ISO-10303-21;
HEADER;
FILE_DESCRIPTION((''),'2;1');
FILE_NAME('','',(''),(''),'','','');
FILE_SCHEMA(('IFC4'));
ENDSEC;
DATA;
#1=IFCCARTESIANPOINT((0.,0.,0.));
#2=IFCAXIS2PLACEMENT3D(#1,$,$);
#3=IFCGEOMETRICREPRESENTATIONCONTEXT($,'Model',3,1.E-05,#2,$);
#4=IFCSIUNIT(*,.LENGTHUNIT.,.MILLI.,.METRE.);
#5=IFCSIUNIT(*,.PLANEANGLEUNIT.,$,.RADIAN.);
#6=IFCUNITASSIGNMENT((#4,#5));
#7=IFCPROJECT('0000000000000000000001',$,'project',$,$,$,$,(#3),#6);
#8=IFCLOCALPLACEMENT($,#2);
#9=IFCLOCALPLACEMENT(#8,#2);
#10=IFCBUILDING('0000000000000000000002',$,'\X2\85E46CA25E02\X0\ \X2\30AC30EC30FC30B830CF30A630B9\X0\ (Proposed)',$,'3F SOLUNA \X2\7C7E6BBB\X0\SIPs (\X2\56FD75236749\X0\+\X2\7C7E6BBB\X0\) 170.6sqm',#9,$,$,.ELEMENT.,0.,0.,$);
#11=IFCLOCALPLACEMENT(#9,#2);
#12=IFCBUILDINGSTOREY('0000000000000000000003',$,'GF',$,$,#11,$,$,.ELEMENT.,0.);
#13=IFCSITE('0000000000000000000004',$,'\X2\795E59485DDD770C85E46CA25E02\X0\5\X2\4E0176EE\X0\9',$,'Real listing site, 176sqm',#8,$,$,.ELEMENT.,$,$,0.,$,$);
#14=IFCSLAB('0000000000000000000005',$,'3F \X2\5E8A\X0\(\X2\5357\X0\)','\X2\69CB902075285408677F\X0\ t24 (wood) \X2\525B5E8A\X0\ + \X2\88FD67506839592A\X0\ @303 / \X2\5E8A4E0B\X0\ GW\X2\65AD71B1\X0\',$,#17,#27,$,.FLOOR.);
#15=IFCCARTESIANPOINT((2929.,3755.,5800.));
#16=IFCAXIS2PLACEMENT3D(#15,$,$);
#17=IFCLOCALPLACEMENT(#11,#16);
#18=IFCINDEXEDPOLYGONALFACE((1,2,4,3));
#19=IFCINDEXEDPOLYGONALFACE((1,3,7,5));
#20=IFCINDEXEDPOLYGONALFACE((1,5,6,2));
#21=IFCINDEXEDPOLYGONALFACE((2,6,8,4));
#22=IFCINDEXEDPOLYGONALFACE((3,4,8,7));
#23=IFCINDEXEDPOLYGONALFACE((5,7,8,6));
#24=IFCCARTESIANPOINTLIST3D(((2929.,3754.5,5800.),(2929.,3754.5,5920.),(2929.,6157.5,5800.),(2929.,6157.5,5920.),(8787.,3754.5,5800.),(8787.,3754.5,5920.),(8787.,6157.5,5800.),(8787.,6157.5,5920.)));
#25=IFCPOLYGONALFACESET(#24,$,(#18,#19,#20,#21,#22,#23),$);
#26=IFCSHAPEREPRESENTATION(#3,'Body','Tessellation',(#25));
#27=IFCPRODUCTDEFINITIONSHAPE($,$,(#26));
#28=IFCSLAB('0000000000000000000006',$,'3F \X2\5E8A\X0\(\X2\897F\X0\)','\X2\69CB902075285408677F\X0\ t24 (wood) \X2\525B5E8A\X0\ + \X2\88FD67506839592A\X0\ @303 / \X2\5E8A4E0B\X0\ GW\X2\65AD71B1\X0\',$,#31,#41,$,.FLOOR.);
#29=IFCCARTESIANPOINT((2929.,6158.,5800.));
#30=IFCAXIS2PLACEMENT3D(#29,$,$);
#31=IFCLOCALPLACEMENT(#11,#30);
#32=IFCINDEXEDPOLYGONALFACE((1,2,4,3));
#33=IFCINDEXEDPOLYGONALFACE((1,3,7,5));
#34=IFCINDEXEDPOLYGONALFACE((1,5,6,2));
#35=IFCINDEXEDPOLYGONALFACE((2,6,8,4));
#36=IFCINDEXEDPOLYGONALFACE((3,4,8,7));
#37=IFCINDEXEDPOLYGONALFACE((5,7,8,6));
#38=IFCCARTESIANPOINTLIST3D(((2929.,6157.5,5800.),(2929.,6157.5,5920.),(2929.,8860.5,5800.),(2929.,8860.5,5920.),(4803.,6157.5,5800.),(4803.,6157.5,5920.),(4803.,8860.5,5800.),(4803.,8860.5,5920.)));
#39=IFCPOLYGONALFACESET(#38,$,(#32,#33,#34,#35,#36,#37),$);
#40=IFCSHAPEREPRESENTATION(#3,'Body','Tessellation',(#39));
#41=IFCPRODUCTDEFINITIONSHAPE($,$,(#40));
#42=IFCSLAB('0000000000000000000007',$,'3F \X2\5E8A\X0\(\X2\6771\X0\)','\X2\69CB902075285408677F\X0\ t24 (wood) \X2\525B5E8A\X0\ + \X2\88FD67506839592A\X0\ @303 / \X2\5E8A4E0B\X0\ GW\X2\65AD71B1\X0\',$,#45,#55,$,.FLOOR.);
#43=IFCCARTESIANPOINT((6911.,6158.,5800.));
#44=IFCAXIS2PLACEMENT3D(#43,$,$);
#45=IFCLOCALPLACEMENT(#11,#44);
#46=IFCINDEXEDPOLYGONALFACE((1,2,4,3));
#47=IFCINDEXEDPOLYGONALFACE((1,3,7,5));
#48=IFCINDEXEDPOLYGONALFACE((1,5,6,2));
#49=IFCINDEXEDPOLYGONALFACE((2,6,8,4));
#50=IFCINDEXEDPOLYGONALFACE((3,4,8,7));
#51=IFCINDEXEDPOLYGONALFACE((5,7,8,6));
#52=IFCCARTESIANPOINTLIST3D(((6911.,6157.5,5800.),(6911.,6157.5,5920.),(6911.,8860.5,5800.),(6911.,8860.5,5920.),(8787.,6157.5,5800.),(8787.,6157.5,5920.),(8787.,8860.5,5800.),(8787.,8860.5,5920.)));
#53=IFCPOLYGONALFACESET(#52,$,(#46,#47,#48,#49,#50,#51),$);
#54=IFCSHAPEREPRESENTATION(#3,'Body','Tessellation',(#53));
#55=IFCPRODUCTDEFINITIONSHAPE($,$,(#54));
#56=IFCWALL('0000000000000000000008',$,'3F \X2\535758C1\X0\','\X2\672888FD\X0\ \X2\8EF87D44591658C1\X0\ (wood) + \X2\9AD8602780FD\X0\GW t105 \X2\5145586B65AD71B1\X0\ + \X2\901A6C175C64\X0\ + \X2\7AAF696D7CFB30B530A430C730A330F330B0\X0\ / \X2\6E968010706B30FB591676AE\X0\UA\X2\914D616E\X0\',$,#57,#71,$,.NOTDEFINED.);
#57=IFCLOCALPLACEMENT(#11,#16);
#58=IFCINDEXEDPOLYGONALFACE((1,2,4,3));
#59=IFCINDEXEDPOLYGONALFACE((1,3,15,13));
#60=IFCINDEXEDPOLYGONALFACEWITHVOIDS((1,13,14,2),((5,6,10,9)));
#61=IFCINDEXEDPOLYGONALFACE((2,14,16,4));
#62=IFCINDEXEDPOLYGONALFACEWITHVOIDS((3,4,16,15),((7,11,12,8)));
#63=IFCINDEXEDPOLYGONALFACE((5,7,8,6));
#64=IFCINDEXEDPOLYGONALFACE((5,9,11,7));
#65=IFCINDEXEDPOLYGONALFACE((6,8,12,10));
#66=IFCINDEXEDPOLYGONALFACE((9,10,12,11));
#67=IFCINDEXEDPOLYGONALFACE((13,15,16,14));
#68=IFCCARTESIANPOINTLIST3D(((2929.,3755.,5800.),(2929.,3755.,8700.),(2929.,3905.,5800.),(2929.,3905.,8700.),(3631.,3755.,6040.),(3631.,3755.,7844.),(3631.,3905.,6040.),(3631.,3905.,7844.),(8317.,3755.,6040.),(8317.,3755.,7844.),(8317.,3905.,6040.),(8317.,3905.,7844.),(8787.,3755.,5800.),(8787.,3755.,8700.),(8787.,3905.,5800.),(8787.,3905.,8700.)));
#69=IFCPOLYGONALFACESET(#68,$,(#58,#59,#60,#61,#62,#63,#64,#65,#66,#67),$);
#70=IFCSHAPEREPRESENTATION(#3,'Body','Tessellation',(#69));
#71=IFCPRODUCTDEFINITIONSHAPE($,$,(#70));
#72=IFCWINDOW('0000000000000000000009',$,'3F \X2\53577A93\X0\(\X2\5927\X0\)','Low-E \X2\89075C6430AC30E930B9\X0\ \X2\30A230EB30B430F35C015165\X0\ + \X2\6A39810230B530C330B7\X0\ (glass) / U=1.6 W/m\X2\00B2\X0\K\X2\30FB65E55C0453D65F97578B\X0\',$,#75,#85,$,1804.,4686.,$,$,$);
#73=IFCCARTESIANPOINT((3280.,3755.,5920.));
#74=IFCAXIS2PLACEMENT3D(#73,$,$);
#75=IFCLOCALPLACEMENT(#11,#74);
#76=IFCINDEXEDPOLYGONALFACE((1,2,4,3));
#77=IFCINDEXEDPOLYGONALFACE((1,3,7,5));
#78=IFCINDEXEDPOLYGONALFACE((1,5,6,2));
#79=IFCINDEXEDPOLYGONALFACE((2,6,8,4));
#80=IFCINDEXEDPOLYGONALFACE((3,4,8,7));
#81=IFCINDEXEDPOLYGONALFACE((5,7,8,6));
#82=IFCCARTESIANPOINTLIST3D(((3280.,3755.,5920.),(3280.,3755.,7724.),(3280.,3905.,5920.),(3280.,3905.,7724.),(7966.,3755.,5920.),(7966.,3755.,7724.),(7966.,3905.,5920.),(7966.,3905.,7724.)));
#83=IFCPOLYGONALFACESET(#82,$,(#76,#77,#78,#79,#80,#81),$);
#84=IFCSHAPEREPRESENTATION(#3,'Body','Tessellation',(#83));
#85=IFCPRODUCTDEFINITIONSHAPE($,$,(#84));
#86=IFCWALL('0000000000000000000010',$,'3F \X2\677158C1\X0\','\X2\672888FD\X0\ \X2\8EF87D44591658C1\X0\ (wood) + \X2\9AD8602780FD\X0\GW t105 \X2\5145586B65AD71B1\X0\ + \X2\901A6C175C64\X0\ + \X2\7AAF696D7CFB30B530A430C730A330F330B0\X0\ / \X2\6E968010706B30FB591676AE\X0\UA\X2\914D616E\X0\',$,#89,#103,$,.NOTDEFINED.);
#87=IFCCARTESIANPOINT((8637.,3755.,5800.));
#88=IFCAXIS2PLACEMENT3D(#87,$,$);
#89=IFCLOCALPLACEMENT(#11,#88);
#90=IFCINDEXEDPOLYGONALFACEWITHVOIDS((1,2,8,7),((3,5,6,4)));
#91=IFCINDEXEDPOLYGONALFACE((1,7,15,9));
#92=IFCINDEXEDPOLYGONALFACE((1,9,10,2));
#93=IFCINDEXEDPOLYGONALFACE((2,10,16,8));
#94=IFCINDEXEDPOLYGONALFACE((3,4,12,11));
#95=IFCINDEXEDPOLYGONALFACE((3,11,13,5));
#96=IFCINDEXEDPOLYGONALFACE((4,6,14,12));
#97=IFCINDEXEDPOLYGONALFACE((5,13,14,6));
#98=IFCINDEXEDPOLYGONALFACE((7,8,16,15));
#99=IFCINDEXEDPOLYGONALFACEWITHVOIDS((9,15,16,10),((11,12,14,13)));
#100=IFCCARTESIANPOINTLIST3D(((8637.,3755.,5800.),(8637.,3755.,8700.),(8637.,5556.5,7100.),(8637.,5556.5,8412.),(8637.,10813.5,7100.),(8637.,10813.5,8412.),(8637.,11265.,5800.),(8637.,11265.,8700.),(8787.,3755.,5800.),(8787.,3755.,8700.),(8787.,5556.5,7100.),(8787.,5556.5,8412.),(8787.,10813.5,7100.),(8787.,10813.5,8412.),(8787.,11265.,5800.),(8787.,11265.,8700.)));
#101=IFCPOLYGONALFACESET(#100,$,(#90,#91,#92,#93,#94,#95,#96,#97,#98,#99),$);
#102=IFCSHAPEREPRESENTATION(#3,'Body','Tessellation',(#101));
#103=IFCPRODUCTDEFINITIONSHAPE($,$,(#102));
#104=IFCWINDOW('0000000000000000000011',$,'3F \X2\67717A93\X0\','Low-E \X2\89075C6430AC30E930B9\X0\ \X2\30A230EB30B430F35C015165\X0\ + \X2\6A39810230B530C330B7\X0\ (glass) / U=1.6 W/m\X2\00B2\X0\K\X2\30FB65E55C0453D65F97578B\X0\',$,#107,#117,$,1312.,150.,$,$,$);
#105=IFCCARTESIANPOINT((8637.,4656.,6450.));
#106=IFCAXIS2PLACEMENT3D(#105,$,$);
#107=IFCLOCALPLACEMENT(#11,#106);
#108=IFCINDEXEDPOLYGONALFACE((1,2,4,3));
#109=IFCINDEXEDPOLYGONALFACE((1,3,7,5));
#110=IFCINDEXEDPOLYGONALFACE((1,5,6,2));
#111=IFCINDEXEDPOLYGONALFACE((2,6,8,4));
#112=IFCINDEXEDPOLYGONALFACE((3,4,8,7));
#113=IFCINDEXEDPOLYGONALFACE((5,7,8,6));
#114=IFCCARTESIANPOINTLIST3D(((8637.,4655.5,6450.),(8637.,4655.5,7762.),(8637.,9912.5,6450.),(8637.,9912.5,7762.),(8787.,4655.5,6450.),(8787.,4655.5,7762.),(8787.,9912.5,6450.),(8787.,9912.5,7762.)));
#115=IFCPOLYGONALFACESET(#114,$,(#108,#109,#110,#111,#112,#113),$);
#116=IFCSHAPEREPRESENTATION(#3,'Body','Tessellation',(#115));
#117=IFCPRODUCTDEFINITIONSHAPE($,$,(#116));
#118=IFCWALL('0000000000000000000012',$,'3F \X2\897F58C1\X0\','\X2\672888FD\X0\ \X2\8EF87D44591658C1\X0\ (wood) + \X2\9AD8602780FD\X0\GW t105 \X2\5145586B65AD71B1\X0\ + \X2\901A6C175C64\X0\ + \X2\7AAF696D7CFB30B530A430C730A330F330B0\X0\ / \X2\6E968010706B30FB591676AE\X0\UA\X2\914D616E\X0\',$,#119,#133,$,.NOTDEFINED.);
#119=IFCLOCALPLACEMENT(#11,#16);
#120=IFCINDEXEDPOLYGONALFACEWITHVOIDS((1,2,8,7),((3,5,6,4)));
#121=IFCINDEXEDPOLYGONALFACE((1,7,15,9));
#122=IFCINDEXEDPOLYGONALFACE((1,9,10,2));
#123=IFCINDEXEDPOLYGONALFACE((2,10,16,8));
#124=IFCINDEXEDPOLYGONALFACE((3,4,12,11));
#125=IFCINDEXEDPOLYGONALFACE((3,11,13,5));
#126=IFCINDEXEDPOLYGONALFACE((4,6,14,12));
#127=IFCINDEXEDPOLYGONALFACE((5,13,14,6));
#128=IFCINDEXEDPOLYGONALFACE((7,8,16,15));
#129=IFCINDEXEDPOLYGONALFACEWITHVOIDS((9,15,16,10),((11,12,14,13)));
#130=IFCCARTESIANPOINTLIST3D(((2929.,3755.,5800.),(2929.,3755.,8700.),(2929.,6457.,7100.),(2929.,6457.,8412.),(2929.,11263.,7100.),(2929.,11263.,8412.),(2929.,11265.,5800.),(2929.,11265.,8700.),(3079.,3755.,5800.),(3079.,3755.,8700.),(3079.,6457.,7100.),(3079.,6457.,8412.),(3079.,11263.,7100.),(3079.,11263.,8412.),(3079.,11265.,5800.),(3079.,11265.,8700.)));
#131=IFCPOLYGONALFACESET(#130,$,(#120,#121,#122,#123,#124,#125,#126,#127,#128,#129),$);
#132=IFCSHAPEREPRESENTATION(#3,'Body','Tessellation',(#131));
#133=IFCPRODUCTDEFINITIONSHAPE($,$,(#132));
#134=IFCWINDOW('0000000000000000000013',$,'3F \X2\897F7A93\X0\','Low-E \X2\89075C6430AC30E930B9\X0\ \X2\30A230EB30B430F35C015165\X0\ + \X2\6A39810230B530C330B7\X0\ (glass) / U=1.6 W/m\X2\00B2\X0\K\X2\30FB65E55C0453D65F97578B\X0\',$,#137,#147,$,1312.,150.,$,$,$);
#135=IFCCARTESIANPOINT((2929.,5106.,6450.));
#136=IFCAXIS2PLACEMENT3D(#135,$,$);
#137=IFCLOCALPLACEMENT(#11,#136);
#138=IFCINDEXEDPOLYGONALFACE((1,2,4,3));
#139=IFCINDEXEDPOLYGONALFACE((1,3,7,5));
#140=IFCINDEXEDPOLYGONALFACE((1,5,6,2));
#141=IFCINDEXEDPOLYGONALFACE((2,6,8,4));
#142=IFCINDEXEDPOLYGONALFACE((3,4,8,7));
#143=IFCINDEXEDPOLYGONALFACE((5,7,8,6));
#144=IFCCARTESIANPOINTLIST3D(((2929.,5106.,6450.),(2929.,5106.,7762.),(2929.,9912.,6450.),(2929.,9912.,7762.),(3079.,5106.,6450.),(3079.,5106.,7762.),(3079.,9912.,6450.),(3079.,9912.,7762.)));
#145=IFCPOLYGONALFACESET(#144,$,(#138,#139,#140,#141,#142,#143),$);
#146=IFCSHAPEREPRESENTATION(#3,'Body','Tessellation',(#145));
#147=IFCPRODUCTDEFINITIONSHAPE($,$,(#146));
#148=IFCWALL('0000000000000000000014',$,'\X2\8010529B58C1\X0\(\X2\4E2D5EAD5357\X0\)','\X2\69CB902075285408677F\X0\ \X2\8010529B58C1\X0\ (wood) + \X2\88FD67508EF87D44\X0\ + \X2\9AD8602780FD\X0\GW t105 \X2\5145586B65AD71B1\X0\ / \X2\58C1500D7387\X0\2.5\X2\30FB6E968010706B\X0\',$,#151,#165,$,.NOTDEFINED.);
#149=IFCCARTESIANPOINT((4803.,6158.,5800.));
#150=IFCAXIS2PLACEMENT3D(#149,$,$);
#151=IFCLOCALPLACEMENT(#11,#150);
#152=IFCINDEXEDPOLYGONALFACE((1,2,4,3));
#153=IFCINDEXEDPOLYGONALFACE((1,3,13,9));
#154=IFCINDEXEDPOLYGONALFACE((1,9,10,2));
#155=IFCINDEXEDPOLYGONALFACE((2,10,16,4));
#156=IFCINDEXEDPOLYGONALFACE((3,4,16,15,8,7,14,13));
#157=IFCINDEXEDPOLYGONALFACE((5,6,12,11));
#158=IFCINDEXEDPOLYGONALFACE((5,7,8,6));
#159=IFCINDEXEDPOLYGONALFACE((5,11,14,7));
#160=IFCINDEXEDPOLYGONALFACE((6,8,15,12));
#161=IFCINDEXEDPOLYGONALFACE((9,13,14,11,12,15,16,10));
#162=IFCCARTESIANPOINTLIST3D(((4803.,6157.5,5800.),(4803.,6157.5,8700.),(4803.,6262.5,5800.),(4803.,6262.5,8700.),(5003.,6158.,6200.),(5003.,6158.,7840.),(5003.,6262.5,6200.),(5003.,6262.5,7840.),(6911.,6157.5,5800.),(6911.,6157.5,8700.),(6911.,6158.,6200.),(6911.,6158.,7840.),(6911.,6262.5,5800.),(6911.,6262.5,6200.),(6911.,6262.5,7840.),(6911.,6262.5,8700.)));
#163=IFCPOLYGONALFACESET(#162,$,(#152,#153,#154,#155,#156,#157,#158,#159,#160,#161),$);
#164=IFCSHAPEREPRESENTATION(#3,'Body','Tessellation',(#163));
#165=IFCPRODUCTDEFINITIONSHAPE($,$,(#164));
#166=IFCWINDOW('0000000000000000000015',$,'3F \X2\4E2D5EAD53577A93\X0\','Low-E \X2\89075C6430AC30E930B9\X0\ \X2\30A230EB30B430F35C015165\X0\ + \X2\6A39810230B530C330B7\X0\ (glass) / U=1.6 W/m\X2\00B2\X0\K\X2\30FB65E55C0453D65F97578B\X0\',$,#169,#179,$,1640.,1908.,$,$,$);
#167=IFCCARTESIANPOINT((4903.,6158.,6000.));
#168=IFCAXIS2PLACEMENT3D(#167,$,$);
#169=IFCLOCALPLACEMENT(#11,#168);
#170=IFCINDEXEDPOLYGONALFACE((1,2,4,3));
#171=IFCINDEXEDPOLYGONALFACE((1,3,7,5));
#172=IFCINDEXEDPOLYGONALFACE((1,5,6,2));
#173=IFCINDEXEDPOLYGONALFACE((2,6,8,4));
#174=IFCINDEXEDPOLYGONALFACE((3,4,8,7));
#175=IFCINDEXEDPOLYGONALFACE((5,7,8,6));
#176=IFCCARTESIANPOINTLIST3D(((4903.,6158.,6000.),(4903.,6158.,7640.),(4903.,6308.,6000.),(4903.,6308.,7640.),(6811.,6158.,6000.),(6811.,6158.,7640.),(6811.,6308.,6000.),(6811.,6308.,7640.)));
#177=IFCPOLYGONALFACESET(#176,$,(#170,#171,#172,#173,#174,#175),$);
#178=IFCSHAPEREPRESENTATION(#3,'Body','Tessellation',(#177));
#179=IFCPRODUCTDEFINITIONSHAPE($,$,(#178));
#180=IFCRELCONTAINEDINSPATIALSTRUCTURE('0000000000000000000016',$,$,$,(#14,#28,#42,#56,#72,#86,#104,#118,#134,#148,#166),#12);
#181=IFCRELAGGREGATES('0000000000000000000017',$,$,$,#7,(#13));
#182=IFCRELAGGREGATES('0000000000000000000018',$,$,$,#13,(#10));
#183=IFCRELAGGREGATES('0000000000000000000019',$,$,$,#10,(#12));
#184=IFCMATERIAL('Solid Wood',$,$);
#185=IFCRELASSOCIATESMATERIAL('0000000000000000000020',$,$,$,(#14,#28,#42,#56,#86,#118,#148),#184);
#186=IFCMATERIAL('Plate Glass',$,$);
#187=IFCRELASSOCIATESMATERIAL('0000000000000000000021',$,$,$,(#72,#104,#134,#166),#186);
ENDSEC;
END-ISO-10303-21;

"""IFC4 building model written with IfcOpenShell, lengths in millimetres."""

from ifc_helpers import new_model, si_unit, frame, frame_2d, origin, place, context, project, spatial, rectangle, extrude, material, element, fill, save


model = new_model("IFC4")

# Units and contexts
model_context = context("Model", 3, precision=1e-05, world=origin())
ifc_project = project(units=[si_unit("LENGTHUNIT", "METRE", prefix="MILLI"), si_unit("PLANEANGLEUNIT", "RADIAN")], contexts=[model_context])

# Site, building, storey
site_placement = place(None, origin())
site = spatial("IfcSite", under=ifc_project, at=site_placement, Name="神奈川県藤沢市5丁目9", ObjectType="Real listing site, 176sqm", CompositionType="ELEMENT", RefElevation=0.0)
building_placement = place(site_placement, origin())
building = spatial("IfcBuilding", under=site, at=building_placement, Name="藤沢市 ガレージハウス (Proposed)", ObjectType="3F SOLUNA 籾殻SIPs (国産杉+籾殻) 170.6sqm", CompositionType="ELEMENT", ElevationOfRefHeight=0.0, ElevationOfTerrain=0.0)
storey_placement = place(building_placement, origin())
storey = spatial("IfcBuildingStorey", under=building, at=storey_placement, Name="GF", CompositionType="ELEMENT", Elevation=0.0)

# Slabs
ifc_material_1 = material(Name="Solid Wood")
slab_1_placement = place(storey_placement, frame((2929.0, 3755.0, 5800.0)))
element("IfcSlab", 1, at=slab_1_placement, inside=storey, material=ifc_material_1, Name="3F 床(南)", Description="構造用合板 t24 (wood) 剛床 + 製材根太 @303 / 床下 GW断熱", PredefinedType="FLOOR", context=model_context, shape_type="SweptSolid", body=[
    extrude(rectangle(XDim=5858.0, YDim=2403.0, at=frame_2d((2929.0, 1201.0))), frame((2929.0, 3755.0, 5800.0)), (0.0, 0.0, 1.0), 120.0),
])
slab_2_placement = place(storey_placement, frame((2929.0, 6158.0, 5800.0)))
element("IfcSlab", 2, at=slab_2_placement, inside=storey, material=ifc_material_1, Name="3F 床(西)", Description="構造用合板 t24 (wood) 剛床 + 製材根太 @303 / 床下 GW断熱", PredefinedType="FLOOR", context=model_context, shape_type="SweptSolid", body=[
    extrude(rectangle(XDim=1874.0, YDim=2703.0, at=frame_2d((937.0, 1351.0))), frame((2929.0, 6158.0, 5800.0)), (0.0, 0.0, 1.0), 120.0),
])
slab_3_placement = place(storey_placement, frame((6911.0, 6158.0, 5800.0)))
element("IfcSlab", 3, at=slab_3_placement, inside=storey, material=ifc_material_1, Name="3F 床(東)", Description="構造用合板 t24 (wood) 剛床 + 製材根太 @303 / 床下 GW断熱", PredefinedType="FLOOR", context=model_context, shape_type="SweptSolid", body=[
    extrude(rectangle(XDim=1876.0, YDim=2703.0, at=frame_2d((938.0, 1351.0))), frame((6911.0, 6158.0, 5800.0)), (0.0, 0.0, 1.0), 120.0),
])

# Walls, openings, windows
wall_1_placement = place(storey_placement, frame((2929.0, 3755.0, 5800.0)))
wall_1 = element("IfcWall", 4, at=wall_1_placement, inside=storey, material=ifc_material_1, Name="3F 南壁", Description="木製 軸組外壁 (wood) + 高性能GW t105 充填断熱 + 通気層 + 窯業系サイディング / 準耐火・外皮UA配慮", PredefinedType="NOTDEFINED", context=model_context, shape_type="SweptSolid", body=[
    extrude(rectangle(XDim=5858.0, YDim=150.0, at=frame_2d((2929.0, 75.0))), frame((2929.0, 3755.0, 5800.0)), (0.0, 0.0, 1.0), 2900.0),
])
opening_1_placement = place(storey_placement, frame((3280.0, 3755.0, 5920.0)))
opening_1 = element("IfcOpeningElement", 5, at=opening_1_placement, cuts=wall_1, PredefinedType="NOTDEFINED", context=model_context, shape_type="SweptSolid", body=[
    extrude(rectangle(XDim=4686.0, YDim=150.0, at=frame_2d((2343.0, 75.0))), frame((3280.0, 3755.0, 5920.0)), (0.0, 0.0, 1.0), 1804.0),
])
ifc_material_2 = material(Name="Plate Glass")
window_1_placement = place(storey_placement, frame((3280.0, 3755.0, 5920.0)))
window_1 = element("IfcWindow", 6, at=window_1_placement, inside=storey, material=ifc_material_2, Name="3F 南窓(大)", Description="Low-E 複層ガラス アルゴン封入 + 樹脂サッシ (glass) / U=1.6 W/m²K・日射取得型", OverallHeight=1804.0, OverallWidth=4686.0, context=model_context, shape_type="SweptSolid", body=[
    extrude(rectangle(XDim=4686.0, YDim=150.0, at=frame_2d((2343.0, 75.0))), frame((3280.0, 3755.0, 5920.0)), (0.0, 0.0, 1.0), 1804.0),
])
fill(opening_1, window_1)
wall_2_placement = place(storey_placement, frame((8637.0, 3755.0, 5800.0)))
wall_2 = element("IfcWall", 7, at=wall_2_placement, inside=storey, material=ifc_material_1, Name="3F 東壁", Description="木製 軸組外壁 (wood) + 高性能GW t105 充填断熱 + 通気層 + 窯業系サイディング / 準耐火・外皮UA配慮", PredefinedType="NOTDEFINED", context=model_context, shape_type="SweptSolid", body=[
    extrude(rectangle(XDim=150.0, YDim=7510.0, at=frame_2d((75.0, 3755.0))), frame((8637.0, 3755.0, 5800.0)), (0.0, 0.0, 1.0), 2900.0),
])
opening_2_placement = place(storey_placement, frame((8637.0, 4656.0, 6450.0)))
opening_2 = element("IfcOpeningElement", 8, at=opening_2_placement, cuts=wall_2, PredefinedType="NOTDEFINED", context=model_context, shape_type="SweptSolid", body=[
    extrude(rectangle(XDim=150.0, YDim=5257.0, at=frame_2d((75.0, 2628.0))), frame((8637.0, 4656.0, 6450.0)), (0.0, 0.0, 1.0), 1312.0),
])
window_2_placement = place(storey_placement, frame((8637.0, 4656.0, 6450.0)))
window_2 = element("IfcWindow", 9, at=window_2_placement, inside=storey, material=ifc_material_2, Name="3F 東窓", Description="Low-E 複層ガラス アルゴン封入 + 樹脂サッシ (glass) / U=1.6 W/m²K・日射取得型", OverallHeight=1312.0, OverallWidth=150.0, context=model_context, shape_type="SweptSolid", body=[
    extrude(rectangle(XDim=150.0, YDim=5257.0, at=frame_2d((75.0, 2628.0))), frame((8637.0, 4656.0, 6450.0)), (0.0, 0.0, 1.0), 1312.0),
])
fill(opening_2, window_2)
wall_3_placement = place(storey_placement, frame((2929.0, 3755.0, 5800.0)))
wall_3 = element("IfcWall", 10, at=wall_3_placement, inside=storey, material=ifc_material_1, Name="3F 西壁", Description="木製 軸組外壁 (wood) + 高性能GW t105 充填断熱 + 通気層 + 窯業系サイディング / 準耐火・外皮UA配慮", PredefinedType="NOTDEFINED", context=model_context, shape_type="SweptSolid", body=[
    extrude(rectangle(XDim=150.0, YDim=7510.0, at=frame_2d((75.0, 3755.0))), frame((2929.0, 3755.0, 5800.0)), (0.0, 0.0, 1.0), 2900.0),
])
opening_3_placement = place(storey_placement, frame((2929.0, 5106.0, 6450.0)))
opening_3 = element("IfcOpeningElement", 11, at=opening_3_placement, cuts=wall_3, PredefinedType="NOTDEFINED", context=model_context, shape_type="SweptSolid", body=[
    extrude(rectangle(XDim=150.0, YDim=4806.0, at=frame_2d((75.0, 2403.0))), frame((2929.0, 5106.0, 6450.0)), (0.0, 0.0, 1.0), 1312.0),
])
window_3_placement = place(storey_placement, frame((2929.0, 5106.0, 6450.0)))
window_3 = element("IfcWindow", 12, at=window_3_placement, inside=storey, material=ifc_material_2, Name="3F 西窓", Description="Low-E 複層ガラス アルゴン封入 + 樹脂サッシ (glass) / U=1.6 W/m²K・日射取得型", OverallHeight=1312.0, OverallWidth=150.0, context=model_context, shape_type="SweptSolid", body=[
    extrude(rectangle(XDim=150.0, YDim=4806.0, at=frame_2d((75.0, 2403.0))), frame((2929.0, 5106.0, 6450.0)), (0.0, 0.0, 1.0), 1312.0),
])
fill(opening_3, window_3)
wall_4_placement = place(storey_placement, frame((4803.0, 6158.0, 5800.0)))
wall_4 = element("IfcWall", 13, at=wall_4_placement, inside=storey, material=ifc_material_1, Name="耐力壁(中庭南)", Description="構造用合板 耐力壁 (wood) + 製材軸組 + 高性能GW t105 充填断熱 / 壁倍率2.5・準耐火", PredefinedType="NOTDEFINED", context=model_context, shape_type="SweptSolid", body=[
    extrude(rectangle(XDim=2108.0, YDim=105.0, at=frame_2d((1054.0, 52.0))), frame((4803.0, 6158.0, 5800.0)), (0.0, 0.0, 1.0), 2900.0),
])
opening_4_placement = place(storey_placement, frame((4903.0, 6158.0, 6000.0)))
opening_4 = element("IfcOpeningElement", 14, at=opening_4_placement, cuts=wall_4, PredefinedType="NOTDEFINED", context=model_context, shape_type="SweptSolid", body=[
    extrude(rectangle(XDim=1908.0, YDim=150.0, at=frame_2d((954.0, 75.0))), frame((4903.0, 6158.0, 6000.0)), (0.0, 0.0, 1.0), 1640.0),
])
window_4_placement = place(storey_placement, frame((4903.0, 6158.0, 6000.0)))
window_4 = element("IfcWindow", 15, at=window_4_placement, inside=storey, material=ifc_material_2, Name="3F 中庭南窓", Description="Low-E 複層ガラス アルゴン封入 + 樹脂サッシ (glass) / U=1.6 W/m²K・日射取得型", OverallHeight=1640.0, OverallWidth=1908.0, context=model_context, shape_type="SweptSolid", body=[
    extrude(rectangle(XDim=1908.0, YDim=150.0, at=frame_2d((954.0, 75.0))), frame((4903.0, 6158.0, 6000.0)), (0.0, 0.0, 1.0), 1640.0),
])
fill(opening_4, window_4)

save(model, "model.ifc")
